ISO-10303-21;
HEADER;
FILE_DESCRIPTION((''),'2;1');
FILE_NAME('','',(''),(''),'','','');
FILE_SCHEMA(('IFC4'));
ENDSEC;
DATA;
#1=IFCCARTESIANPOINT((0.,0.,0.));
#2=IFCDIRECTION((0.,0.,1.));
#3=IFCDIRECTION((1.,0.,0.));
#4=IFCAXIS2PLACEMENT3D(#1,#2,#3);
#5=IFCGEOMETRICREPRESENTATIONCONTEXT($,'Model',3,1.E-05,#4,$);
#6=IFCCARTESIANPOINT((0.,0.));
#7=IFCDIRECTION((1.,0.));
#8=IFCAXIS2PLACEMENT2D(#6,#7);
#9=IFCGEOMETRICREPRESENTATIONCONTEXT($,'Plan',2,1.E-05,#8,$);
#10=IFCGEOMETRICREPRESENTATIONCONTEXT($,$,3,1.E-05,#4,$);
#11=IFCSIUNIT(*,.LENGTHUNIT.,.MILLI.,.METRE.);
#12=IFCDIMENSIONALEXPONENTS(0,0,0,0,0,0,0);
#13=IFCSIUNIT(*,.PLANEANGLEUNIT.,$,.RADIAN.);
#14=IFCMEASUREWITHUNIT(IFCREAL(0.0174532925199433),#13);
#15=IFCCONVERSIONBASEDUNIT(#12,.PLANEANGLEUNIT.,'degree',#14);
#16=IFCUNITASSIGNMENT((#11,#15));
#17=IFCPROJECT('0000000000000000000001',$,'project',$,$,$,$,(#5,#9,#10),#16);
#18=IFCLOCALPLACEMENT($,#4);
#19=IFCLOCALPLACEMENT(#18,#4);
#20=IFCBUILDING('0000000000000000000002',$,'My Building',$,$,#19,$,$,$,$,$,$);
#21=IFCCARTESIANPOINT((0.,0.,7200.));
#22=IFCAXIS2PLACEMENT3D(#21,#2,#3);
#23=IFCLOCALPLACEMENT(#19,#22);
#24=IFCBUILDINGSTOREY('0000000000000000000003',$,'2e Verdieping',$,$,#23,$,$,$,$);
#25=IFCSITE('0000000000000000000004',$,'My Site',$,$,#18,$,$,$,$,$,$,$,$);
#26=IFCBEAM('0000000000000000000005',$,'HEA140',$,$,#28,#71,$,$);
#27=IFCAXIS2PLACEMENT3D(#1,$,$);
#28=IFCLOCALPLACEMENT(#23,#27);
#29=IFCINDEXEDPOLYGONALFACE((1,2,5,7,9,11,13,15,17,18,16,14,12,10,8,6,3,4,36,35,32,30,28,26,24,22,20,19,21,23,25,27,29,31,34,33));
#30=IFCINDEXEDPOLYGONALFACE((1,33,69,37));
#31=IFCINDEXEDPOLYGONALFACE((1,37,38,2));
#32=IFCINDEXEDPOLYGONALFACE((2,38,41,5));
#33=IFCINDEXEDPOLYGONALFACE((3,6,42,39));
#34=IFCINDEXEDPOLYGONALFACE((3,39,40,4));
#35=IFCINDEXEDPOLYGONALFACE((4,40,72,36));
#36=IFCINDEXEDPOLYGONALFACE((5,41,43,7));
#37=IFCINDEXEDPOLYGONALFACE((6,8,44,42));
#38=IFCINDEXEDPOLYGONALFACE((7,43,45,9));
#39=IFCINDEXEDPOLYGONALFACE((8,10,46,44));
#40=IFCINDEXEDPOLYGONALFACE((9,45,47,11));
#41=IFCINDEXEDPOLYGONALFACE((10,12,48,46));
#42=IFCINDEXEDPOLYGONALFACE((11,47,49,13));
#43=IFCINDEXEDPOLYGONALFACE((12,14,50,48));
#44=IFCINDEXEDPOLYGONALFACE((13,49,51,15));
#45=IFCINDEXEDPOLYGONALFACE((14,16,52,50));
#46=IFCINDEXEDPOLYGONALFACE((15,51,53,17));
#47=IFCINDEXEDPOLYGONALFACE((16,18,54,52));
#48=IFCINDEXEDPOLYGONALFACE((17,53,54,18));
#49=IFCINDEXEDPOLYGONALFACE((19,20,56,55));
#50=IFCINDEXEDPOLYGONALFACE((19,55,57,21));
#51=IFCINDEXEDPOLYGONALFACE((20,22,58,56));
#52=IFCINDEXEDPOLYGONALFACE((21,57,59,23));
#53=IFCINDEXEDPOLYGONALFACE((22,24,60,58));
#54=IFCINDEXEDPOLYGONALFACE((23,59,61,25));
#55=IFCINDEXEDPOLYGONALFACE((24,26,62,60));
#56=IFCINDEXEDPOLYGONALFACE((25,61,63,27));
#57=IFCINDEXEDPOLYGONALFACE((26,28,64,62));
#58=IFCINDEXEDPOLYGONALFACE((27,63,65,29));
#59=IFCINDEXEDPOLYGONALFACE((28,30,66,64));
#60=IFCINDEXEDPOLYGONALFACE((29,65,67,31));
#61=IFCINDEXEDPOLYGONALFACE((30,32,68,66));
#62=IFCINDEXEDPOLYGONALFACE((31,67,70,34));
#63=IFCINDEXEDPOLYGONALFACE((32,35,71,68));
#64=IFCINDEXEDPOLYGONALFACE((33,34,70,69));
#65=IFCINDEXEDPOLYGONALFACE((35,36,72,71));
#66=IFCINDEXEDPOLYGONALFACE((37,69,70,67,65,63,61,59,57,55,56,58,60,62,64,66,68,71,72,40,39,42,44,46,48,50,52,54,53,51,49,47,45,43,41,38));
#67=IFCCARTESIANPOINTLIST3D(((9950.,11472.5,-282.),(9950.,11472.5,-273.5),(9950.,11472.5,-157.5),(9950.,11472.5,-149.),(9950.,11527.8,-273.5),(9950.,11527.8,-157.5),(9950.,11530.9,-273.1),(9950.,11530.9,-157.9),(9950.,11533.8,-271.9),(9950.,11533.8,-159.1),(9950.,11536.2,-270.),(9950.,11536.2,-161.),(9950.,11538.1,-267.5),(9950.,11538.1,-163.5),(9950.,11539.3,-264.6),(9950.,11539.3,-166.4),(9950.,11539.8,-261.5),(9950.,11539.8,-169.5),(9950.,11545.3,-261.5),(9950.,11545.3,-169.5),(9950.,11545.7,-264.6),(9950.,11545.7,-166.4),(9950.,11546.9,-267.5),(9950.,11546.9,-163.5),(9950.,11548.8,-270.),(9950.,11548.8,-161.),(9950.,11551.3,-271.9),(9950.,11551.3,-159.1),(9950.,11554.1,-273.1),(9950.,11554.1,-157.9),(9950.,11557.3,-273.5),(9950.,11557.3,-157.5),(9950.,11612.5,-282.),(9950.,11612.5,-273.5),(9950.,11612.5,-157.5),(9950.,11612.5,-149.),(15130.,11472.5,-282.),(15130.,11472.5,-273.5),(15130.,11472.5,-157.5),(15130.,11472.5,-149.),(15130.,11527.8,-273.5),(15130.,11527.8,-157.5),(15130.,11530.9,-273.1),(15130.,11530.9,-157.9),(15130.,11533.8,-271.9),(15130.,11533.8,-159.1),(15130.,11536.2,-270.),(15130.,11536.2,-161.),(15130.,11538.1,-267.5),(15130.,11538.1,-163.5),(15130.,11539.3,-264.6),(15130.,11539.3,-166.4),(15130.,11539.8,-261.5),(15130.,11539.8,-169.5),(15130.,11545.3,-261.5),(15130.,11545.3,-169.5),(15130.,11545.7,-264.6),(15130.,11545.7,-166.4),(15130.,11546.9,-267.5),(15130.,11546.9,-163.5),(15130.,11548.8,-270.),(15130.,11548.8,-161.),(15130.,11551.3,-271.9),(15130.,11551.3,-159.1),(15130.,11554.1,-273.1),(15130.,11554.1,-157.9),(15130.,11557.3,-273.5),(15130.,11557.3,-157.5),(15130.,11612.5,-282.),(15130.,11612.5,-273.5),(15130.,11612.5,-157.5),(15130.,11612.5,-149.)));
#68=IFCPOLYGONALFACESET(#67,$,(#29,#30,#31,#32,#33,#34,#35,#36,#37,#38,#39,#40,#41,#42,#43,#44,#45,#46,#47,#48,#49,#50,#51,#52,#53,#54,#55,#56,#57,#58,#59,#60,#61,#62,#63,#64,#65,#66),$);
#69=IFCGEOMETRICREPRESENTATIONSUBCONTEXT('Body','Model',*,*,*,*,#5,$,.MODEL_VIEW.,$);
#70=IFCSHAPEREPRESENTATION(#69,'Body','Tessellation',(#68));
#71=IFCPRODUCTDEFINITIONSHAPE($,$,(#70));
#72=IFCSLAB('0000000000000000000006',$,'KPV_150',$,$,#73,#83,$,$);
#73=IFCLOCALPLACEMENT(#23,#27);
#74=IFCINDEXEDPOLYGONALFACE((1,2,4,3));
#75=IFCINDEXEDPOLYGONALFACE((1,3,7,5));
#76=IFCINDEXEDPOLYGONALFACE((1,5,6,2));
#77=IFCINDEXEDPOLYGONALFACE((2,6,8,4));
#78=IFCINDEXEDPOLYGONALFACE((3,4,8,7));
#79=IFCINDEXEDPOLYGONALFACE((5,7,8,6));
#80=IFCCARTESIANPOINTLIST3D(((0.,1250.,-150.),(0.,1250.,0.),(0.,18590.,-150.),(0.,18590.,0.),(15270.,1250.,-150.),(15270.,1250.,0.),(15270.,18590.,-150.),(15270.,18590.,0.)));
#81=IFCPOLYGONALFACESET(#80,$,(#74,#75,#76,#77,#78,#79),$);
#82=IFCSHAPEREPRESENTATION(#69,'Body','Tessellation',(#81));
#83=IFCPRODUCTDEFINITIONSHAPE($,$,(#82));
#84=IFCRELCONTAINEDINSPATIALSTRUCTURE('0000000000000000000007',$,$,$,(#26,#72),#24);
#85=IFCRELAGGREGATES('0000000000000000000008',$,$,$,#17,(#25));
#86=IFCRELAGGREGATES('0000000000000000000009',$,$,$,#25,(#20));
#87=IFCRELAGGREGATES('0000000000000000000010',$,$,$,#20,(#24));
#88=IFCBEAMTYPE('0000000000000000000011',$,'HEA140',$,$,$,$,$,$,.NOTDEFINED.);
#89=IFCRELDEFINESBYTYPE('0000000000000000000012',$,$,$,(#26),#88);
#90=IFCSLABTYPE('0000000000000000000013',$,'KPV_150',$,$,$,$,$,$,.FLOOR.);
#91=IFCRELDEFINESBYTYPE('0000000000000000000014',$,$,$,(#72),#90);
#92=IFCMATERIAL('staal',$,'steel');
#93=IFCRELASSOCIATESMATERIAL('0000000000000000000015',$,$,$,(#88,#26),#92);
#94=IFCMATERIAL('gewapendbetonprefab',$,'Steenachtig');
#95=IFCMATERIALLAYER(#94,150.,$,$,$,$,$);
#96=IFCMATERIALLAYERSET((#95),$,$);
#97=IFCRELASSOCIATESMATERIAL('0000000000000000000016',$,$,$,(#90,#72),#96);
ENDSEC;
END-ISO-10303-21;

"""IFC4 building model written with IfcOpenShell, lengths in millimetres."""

from ifc_helpers import new_model, entity, si_unit, converted_unit, frame, origin_with_axes, origin_2d_with_axis, place, context, subcontext, project, spatial, line, indexed_curve, i_section, outline, extrude, material, layer, layer_set, layer_usage, material_profile, profile_set, profile_usage, type_object, element, save


model = new_model("IFC4")

# Units and contexts
model_context = context("Model", 3, precision=1e-05, world=origin_with_axes())
plan_context = context("Plan", 2, precision=1e-05, world=origin_2d_with_axis())
context_of_model = context(None, 3, precision=1e-05, world=origin_with_axes())
body_context = subcontext(model_context, "Body", "Model", "MODEL_VIEW")
ifc_project = project(units=[si_unit("LENGTHUNIT", "METRE", prefix="MILLI"), converted_unit("PLANEANGLEUNIT", "degree", entity("IfcReal", 0.0174532925199433), si_unit("PLANEANGLEUNIT", "RADIAN"), dimensions=[0, 0, 0, 0, 0, 0, 0])], contexts=[model_context, plan_context, context_of_model])

# Site, building, storey
site_placement = place(None, origin_with_axes())
site = spatial("IfcSite", under=ifc_project, at=site_placement, Name="My Site")
building_placement = place(site_placement, origin_with_axes())
building = spatial("IfcBuilding", under=site, at=building_placement, Name="My Building")
storey_placement = place(building_placement, frame((0.0, 0.0, 7200.0), z_axis=(0.0, 0.0, 1.0), x_axis=(1.0, 0.0, 0.0)))
storey = spatial("IfcBuildingStorey", under=building, at=storey_placement, Name="2e Verdieping")

# Beam
ifc_material_1 = material(Name="staal", Category="steel")
ifc_material_profile_1 = material_profile(ifc_material_1, i_section(OverallWidth=140.0, OverallDepth=133.0, WebThickness=5.5, FlangeThickness=8.5, FilletRadius=12.0))
ifc_profile_set_1 = profile_set([ifc_material_profile_1], Name="HEA140")
beam_type_1 = type_object("IfcBeamType", Name="HEA140", PredefinedType="NOTDEFINED", material=ifc_profile_set_1)
ifc_profile_usage_1 = profile_usage(ifc_profile_set_1)
beam_1_placement = place(storey_placement, frame((9950.0, 11542.5, -215.5), z_axis=(1.0, 0.0, 0.0), x_axis=(0.0, 1.0, 0.0)))
element("IfcBeam", 1, at=beam_1_placement, inside=storey, type_object=beam_type_1, material=ifc_profile_usage_1, Name="HEA140", context=body_context, shape_type="SweptSolid", body=[
    extrude(i_section(OverallWidth=140.0, OverallDepth=133.0, WebThickness=5.5, FlangeThickness=8.5, FilletRadius=12.0), origin_with_axes(), (0.0, 0.0, 1.0), 5180.0),
])

# Slab
ifc_material_2 = material(Name="gewapendbetonprefab", Category="Steenachtig")
ifc_layer = layer(ifc_material_2, 150.0)
ifc_layer_set = layer_set([ifc_layer])
ifc_layer_usage = layer_usage(ifc_layer_set, "AXIS3", "POSITIVE", 0.0)
slab_type = type_object("IfcSlabType", Name="KPV_150", PredefinedType="FLOOR", material=ifc_layer_set)
slab_placement = place(storey_placement, frame((0.0, 18590.0, -150.0), z_axis=(0.0, 0.0, 1.0), x_axis=(1.0, 0.0, 0.0)))
element("IfcSlab", 2, at=slab_placement, inside=storey, type_object=slab_type, material=ifc_layer_usage, Name="KPV_150", context=body_context, shape_type="SweptSolid", body=[
    extrude(outline(indexed_curve([(0.0, 0.0), (0.0, -17340.0), (15270.0, -17340.0), (15270.0, 0.0)], segments=[line(3, 2), line(2, 1), line(1, 4), line(4, 3)], self_intersect=False)), None, (0.0, 0.0, 1.0), 150.0),
])

save(model, "model.ifc")
